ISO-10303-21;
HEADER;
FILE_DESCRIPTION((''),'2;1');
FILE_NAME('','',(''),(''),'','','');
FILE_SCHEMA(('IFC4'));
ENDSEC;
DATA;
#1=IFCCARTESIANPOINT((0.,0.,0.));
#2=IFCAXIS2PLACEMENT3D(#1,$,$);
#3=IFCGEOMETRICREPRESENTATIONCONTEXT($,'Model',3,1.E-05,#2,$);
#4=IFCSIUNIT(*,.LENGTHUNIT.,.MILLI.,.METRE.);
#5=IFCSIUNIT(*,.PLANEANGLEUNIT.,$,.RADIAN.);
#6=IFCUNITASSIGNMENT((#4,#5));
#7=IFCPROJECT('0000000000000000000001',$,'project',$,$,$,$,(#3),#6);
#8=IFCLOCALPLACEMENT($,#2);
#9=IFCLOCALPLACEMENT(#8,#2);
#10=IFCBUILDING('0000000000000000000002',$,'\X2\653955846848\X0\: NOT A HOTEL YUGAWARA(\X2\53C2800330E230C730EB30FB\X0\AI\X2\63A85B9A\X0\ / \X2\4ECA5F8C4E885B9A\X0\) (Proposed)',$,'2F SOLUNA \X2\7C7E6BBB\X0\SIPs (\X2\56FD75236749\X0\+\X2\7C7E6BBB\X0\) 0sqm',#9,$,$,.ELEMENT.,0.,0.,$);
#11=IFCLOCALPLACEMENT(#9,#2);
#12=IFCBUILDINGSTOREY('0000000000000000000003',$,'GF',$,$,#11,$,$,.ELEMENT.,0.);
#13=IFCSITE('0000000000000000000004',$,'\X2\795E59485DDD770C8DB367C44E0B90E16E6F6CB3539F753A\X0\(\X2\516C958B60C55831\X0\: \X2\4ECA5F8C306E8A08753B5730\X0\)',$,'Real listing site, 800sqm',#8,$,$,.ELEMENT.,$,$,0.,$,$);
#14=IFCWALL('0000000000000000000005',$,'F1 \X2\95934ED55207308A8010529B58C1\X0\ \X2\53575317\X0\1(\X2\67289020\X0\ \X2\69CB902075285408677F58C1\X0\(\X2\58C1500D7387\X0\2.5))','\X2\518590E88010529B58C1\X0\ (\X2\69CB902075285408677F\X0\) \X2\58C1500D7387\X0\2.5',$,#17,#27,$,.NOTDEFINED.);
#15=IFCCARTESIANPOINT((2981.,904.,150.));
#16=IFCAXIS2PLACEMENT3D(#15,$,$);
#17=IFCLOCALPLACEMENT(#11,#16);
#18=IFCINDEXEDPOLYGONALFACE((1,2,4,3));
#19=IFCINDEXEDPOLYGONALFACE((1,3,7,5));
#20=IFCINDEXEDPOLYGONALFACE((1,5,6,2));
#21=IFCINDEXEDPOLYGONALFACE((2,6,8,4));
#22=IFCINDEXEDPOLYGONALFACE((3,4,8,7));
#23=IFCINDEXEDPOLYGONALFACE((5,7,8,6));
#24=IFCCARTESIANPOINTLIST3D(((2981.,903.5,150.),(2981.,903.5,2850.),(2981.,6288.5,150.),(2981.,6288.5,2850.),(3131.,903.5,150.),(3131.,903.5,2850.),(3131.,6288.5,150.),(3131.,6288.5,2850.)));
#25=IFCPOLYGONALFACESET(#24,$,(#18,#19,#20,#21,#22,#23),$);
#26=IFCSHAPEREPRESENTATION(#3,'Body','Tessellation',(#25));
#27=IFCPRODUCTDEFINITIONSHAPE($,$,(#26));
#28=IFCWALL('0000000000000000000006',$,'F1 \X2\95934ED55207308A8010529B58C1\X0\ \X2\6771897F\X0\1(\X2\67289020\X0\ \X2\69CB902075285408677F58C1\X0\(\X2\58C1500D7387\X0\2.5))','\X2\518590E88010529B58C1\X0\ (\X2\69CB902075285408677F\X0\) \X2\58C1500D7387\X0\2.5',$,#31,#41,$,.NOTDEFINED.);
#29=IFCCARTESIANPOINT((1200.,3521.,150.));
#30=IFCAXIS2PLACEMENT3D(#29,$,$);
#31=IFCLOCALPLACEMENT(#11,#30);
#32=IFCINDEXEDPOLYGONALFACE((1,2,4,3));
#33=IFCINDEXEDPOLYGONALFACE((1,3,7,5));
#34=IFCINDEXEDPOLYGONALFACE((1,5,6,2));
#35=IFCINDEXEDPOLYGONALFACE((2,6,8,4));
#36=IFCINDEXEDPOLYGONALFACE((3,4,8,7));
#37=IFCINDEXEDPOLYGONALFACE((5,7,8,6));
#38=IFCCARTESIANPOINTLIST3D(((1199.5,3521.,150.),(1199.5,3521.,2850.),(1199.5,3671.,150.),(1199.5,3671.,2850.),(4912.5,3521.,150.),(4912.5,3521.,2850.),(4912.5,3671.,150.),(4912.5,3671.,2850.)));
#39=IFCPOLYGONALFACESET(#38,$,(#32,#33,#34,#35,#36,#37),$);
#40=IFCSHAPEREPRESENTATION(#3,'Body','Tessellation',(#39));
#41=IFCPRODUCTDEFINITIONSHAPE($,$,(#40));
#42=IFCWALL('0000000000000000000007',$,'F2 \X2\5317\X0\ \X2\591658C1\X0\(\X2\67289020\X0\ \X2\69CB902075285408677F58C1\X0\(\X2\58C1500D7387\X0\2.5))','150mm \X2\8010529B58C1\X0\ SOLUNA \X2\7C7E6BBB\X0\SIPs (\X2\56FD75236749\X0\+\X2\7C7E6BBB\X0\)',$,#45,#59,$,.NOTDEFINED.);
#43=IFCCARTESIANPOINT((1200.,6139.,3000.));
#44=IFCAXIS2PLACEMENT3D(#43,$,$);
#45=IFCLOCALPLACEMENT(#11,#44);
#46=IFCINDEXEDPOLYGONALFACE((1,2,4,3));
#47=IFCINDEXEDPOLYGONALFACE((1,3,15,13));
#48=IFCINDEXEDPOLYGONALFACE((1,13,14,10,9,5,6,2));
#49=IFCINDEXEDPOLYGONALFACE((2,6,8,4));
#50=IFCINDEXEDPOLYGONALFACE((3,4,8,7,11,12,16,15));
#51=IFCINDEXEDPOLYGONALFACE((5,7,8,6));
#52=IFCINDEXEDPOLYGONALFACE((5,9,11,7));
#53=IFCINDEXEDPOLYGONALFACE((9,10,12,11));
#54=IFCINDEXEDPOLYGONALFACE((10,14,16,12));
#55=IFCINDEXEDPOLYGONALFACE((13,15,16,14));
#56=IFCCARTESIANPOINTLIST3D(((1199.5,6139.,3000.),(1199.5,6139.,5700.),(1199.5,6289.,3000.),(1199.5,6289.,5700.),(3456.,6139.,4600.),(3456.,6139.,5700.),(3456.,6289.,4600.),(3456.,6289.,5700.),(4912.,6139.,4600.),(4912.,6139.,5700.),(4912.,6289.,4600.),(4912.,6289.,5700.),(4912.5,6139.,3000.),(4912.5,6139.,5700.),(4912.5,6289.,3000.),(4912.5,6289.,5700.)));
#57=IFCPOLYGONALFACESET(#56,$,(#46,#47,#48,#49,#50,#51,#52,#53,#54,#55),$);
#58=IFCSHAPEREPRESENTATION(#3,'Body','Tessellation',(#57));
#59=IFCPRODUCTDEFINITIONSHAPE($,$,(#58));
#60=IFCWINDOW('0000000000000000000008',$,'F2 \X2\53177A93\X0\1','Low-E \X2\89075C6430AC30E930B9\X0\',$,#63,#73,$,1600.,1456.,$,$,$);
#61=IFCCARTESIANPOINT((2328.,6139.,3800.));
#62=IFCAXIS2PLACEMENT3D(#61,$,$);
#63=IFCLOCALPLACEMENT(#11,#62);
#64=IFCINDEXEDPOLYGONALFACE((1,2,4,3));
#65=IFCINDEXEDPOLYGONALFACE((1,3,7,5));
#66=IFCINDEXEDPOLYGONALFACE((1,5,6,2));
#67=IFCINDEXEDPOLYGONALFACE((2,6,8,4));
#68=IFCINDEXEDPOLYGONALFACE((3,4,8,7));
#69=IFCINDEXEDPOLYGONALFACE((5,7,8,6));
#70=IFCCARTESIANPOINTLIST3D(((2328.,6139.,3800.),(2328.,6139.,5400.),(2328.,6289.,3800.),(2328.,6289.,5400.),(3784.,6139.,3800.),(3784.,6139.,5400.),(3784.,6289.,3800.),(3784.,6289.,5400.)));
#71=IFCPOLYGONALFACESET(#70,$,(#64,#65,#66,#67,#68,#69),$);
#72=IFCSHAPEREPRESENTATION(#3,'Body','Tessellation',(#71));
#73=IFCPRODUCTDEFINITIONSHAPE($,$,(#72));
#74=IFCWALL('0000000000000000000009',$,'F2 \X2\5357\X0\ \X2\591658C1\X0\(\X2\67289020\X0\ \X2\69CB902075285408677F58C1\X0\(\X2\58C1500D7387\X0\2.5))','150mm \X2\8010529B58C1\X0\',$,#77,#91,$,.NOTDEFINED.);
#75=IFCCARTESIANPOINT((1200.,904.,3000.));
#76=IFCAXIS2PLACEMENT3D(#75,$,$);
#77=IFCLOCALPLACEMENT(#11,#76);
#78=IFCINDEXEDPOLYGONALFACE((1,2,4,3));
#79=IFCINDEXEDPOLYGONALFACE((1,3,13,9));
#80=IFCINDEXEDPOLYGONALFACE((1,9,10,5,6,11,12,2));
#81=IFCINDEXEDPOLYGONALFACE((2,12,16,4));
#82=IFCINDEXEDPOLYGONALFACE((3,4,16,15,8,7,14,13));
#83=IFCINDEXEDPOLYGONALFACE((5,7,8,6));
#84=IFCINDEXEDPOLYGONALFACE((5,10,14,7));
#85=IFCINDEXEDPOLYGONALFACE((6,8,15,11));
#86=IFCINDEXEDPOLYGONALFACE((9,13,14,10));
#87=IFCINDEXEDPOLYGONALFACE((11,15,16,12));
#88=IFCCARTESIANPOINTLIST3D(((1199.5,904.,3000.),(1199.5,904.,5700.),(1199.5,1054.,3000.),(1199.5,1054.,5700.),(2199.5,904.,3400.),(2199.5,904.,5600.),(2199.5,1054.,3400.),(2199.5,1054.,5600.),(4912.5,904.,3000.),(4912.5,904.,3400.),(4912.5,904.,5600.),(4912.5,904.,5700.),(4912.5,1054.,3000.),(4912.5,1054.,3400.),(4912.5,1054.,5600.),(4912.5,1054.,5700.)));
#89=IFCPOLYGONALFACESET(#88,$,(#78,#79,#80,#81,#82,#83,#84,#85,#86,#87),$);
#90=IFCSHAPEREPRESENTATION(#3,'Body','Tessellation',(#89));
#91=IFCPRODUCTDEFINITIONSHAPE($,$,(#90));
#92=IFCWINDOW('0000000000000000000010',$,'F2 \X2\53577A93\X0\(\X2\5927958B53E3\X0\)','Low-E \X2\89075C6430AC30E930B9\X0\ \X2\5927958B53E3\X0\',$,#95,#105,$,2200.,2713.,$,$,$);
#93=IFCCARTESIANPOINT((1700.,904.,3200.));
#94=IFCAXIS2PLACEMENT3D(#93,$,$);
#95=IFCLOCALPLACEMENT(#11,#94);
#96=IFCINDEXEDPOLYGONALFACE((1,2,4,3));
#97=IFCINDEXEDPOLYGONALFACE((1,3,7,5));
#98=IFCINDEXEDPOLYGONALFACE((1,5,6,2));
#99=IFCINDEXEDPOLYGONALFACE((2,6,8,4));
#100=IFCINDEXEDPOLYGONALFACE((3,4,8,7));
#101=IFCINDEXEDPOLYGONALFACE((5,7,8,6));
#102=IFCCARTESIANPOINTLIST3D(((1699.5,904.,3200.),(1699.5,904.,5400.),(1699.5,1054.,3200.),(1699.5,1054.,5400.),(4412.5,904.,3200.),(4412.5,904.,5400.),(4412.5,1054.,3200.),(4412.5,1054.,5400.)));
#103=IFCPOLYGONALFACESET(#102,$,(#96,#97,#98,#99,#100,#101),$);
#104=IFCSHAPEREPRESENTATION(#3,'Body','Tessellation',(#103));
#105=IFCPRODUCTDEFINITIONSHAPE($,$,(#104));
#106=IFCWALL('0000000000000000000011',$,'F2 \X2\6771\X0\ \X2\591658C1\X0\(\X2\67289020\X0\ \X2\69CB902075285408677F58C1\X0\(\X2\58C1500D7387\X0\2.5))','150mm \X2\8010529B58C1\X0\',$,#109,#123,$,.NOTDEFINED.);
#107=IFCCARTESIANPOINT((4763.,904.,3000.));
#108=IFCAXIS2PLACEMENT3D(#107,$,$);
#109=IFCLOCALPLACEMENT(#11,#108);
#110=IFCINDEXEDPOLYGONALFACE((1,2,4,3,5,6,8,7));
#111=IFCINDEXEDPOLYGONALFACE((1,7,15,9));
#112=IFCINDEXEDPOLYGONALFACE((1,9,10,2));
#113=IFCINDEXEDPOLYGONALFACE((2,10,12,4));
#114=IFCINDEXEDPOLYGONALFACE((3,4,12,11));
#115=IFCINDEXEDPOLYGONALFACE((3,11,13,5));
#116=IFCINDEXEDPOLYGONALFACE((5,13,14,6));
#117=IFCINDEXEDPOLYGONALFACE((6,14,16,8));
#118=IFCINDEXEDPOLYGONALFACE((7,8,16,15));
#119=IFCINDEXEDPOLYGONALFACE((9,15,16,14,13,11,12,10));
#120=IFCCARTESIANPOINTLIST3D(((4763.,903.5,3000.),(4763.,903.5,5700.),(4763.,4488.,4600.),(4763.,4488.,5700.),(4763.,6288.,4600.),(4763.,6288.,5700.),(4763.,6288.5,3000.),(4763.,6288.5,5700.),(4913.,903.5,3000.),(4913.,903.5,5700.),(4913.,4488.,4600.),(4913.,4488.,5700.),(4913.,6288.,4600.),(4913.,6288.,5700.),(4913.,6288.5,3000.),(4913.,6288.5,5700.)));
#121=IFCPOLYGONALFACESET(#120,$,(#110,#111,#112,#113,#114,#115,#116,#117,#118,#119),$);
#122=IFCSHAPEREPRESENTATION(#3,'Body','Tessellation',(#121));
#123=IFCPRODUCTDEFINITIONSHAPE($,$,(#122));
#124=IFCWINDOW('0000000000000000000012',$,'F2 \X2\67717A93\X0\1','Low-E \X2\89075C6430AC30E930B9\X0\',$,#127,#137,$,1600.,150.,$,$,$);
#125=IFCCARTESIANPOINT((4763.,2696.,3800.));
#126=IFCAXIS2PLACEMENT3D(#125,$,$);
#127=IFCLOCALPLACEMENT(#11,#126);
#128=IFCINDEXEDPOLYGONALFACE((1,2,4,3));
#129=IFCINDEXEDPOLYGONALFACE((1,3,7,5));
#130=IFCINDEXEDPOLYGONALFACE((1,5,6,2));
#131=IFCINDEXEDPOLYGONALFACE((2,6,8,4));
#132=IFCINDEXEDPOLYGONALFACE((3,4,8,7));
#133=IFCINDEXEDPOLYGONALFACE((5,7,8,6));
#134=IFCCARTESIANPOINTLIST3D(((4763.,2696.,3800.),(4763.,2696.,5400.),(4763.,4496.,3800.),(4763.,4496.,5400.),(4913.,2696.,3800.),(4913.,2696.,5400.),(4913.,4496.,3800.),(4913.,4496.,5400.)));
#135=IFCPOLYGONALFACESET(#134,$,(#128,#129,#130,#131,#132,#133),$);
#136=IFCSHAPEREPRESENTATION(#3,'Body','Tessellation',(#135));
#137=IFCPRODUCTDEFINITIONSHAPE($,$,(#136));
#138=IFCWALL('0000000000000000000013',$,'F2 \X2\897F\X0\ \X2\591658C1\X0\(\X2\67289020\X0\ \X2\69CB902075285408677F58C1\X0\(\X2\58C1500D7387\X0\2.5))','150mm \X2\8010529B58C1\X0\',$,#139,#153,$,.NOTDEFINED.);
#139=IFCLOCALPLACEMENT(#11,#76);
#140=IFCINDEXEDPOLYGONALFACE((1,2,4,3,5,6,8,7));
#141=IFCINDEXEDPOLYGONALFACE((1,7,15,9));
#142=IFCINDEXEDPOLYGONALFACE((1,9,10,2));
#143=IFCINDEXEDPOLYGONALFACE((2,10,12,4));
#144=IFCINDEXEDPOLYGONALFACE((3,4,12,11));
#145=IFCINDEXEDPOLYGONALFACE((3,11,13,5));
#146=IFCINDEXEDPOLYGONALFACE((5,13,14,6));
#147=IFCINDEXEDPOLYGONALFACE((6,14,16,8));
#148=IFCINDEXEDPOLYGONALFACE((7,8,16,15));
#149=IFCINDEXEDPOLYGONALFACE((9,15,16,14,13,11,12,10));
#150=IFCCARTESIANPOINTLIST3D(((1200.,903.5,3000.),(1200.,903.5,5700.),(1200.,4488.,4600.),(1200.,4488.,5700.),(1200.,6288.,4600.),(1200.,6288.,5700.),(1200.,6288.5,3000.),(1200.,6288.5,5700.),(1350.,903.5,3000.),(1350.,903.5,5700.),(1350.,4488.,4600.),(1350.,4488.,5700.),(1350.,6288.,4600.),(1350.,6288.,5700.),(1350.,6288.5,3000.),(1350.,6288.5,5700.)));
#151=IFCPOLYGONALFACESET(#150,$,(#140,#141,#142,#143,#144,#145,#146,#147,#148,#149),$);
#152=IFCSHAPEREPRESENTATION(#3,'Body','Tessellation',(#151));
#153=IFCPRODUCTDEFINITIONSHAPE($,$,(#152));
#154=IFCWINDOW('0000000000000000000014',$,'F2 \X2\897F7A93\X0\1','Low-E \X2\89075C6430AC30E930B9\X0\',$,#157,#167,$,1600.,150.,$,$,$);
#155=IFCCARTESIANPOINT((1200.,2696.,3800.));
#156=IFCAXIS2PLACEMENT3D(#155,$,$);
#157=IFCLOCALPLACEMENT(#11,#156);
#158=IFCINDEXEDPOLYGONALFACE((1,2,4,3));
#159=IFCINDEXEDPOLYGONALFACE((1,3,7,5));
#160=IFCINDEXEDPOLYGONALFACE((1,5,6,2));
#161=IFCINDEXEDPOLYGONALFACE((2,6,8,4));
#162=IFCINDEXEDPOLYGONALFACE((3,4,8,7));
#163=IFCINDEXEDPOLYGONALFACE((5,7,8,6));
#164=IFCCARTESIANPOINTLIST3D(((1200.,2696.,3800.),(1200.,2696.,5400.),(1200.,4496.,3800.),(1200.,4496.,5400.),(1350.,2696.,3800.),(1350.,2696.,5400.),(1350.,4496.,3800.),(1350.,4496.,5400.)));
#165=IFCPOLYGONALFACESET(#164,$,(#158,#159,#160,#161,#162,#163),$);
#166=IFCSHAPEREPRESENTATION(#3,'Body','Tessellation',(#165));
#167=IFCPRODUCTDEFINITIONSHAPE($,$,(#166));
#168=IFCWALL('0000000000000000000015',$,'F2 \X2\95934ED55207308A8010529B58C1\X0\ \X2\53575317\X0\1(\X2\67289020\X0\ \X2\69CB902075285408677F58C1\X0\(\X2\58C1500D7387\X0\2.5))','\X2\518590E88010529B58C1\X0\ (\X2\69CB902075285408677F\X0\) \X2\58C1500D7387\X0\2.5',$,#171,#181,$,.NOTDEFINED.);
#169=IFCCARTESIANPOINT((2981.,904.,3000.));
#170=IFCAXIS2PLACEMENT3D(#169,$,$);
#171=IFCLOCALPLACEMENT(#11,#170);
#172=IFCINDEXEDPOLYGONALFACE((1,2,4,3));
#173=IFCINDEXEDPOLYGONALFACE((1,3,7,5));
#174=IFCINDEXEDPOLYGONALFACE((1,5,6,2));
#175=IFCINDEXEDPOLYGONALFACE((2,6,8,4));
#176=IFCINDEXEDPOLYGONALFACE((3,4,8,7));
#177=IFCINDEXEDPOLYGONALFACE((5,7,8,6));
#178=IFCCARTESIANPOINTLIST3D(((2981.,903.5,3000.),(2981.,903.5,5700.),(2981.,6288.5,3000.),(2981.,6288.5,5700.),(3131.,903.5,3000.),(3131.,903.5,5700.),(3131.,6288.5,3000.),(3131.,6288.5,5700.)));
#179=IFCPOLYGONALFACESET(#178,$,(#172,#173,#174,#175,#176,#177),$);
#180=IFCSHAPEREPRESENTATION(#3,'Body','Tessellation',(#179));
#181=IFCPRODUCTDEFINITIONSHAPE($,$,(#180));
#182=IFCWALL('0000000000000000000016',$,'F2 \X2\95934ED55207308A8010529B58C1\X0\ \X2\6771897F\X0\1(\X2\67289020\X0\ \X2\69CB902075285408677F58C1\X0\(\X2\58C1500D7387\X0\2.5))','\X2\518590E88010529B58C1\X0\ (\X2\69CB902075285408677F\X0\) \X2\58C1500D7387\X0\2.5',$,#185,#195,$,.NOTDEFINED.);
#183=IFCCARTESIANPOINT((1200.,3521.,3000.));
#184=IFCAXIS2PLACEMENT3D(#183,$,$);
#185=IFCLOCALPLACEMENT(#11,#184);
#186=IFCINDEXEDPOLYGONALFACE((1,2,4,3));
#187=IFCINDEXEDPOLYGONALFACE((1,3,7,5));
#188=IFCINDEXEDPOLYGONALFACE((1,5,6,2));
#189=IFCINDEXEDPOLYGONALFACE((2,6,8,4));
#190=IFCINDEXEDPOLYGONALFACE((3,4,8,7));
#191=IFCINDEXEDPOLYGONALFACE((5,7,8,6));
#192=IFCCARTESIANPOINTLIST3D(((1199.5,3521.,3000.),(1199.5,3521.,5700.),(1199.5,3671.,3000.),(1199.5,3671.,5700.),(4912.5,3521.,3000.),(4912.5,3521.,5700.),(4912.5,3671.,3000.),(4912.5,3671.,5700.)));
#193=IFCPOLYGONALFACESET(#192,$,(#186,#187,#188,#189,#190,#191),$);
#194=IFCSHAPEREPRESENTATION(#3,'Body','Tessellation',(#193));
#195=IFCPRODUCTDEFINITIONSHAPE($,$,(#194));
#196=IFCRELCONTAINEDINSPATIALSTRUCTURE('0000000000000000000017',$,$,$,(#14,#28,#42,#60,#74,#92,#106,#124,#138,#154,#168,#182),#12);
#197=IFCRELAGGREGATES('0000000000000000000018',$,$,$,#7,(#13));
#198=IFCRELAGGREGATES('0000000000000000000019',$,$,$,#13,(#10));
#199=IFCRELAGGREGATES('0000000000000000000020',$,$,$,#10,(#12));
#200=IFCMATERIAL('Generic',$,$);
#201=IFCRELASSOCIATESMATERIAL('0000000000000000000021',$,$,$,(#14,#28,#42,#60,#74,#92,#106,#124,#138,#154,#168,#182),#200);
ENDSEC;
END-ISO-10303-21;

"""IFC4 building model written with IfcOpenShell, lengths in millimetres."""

from ifc_helpers import new_model, si_unit, frame, frame_2d, origin, place, context, project, spatial, rectangle, extrude, material, element, fill, save


model = new_model("IFC4")

# Units and contexts
model_context = context("Model", 3, precision=1e-05, world=origin())
ifc_project = project(units=[si_unit("LENGTHUNIT", "METRE", prefix="MILLI"), si_unit("PLANEANGLEUNIT", "RADIAN")], contexts=[model_context])

# Site, building, storey
site_placement = place(None, origin())
site = spatial("IfcSite", under=ifc_project, at=site_placement, Name="神奈川県足柄下郡湯河原町(公開情報: 今後の計画地)", ObjectType="Real listing site, 800sqm", CompositionType="ELEMENT", RefElevation=0.0)
building_placement = place(site_placement, origin())
building = spatial("IfcBuilding", under=site, at=building_placement, Name="改善案: NOT A HOTEL YUGAWARA(参考モデル・AI推定 / 今後予定) (Proposed)", ObjectType="2F SOLUNA 籾殻SIPs (国産杉+籾殻) 0sqm", CompositionType="ELEMENT", ElevationOfRefHeight=0.0, ElevationOfTerrain=0.0)
storey_placement = place(building_placement, origin())
storey = spatial("IfcBuildingStorey", under=building, at=storey_placement, Name="GF", CompositionType="ELEMENT", Elevation=0.0)

# Shared definitions
ifc_material_1 = material(Name="Generic")

# Walls
wall_1_placement = place(storey_placement, frame((2981.0, 904.0, 150.0)))
element("IfcWall", 1, at=wall_1_placement, inside=storey, material=ifc_material_1, Name="F1 間仕切り耐力壁 南北1(木造 構造用合板壁(壁倍率2.5))", Description="内部耐力壁 (構造用合板) 壁倍率2.5", PredefinedType="NOTDEFINED", context=model_context, shape_type="SweptSolid", body=[
    extrude(rectangle(XDim=150.0, YDim=5385.0, at=frame_2d((75.0, 2692.0))), frame((2981.0, 904.0, 150.0)), (0.0, 0.0, 1.0), 2700.0),
])
wall_2_placement = place(storey_placement, frame((1200.0, 3521.0, 150.0)))
element("IfcWall", 2, at=wall_2_placement, inside=storey, material=ifc_material_1, Name="F1 間仕切り耐力壁 東西1(木造 構造用合板壁(壁倍率2.5))", Description="内部耐力壁 (構造用合板) 壁倍率2.5", PredefinedType="NOTDEFINED", context=model_context, shape_type="SweptSolid", body=[
    extrude(rectangle(XDim=3713.0, YDim=150.0, at=frame_2d((1856.0, 75.0))), frame((1200.0, 3521.0, 150.0)), (0.0, 0.0, 1.0), 2700.0),
])

# Walls, openings, windows
wall_3_placement = place(storey_placement, frame((1200.0, 6139.0, 3000.0)))
wall_3 = element("IfcWall", 3, at=wall_3_placement, inside=storey, material=ifc_material_1, Name="F2 北 外壁(木造 構造用合板壁(壁倍率2.5))", Description="150mm 耐力壁 SOLUNA 籾殻SIPs (国産杉+籾殻)", PredefinedType="NOTDEFINED", context=model_context, shape_type="SweptSolid", body=[
    extrude(rectangle(XDim=3713.0, YDim=150.0, at=frame_2d((1856.0, 75.0))), frame((1200.0, 6139.0, 3000.0)), (0.0, 0.0, 1.0), 2700.0),
])
opening_1_placement = place(storey_placement, frame((2328.0, 6139.0, 3800.0)))
opening_1 = element("IfcOpeningElement", 4, at=opening_1_placement, cuts=wall_3, PredefinedType="NOTDEFINED", context=model_context, shape_type="SweptSolid", body=[
    extrude(rectangle(XDim=1456.0, YDim=150.0, at=frame_2d((728.0, 75.0))), frame((2328.0, 6139.0, 3800.0)), (0.0, 0.0, 1.0), 1600.0),
])
window_1_placement = place(storey_placement, frame((2328.0, 6139.0, 3800.0)))
window_1 = element("IfcWindow", 5, at=window_1_placement, inside=storey, material=ifc_material_1, Name="F2 北窓1", Description="Low-E 複層ガラス", OverallHeight=1600.0, OverallWidth=1456.0, context=model_context, shape_type="SweptSolid", body=[
    extrude(rectangle(XDim=1456.0, YDim=150.0, at=frame_2d((728.0, 75.0))), frame((2328.0, 6139.0, 3800.0)), (0.0, 0.0, 1.0), 1600.0),
])
fill(opening_1, window_1)
wall_4_placement = place(storey_placement, frame((1200.0, 904.0, 3000.0)))
wall_4 = element("IfcWall", 6, at=wall_4_placement, inside=storey, material=ifc_material_1, Name="F2 南 外壁(木造 構造用合板壁(壁倍率2.5))", Description="150mm 耐力壁", PredefinedType="NOTDEFINED", context=model_context, shape_type="SweptSolid", body=[
    extrude(rectangle(XDim=3713.0, YDim=150.0, at=frame_2d((1856.0, 75.0))), frame((1200.0, 904.0, 3000.0)), (0.0, 0.0, 1.0), 2700.0),
])
opening_2_placement = place(storey_placement, frame((1700.0, 904.0, 3200.0)))
opening_2 = element("IfcOpeningElement", 7, at=opening_2_placement, cuts=wall_4, PredefinedType="NOTDEFINED", context=model_context, shape_type="SweptSolid", body=[
    extrude(rectangle(XDim=2713.0, YDim=150.0, at=frame_2d((1356.0, 75.0))), frame((1700.0, 904.0, 3200.0)), (0.0, 0.0, 1.0), 2200.0),
])
window_2_placement = place(storey_placement, frame((1700.0, 904.0, 3200.0)))
window_2 = element("IfcWindow", 8, at=window_2_placement, inside=storey, material=ifc_material_1, Name="F2 南窓(大開口)", Description="Low-E 複層ガラス 大開口", OverallHeight=2200.0, OverallWidth=2713.0, context=model_context, shape_type="SweptSolid", body=[
    extrude(rectangle(XDim=2713.0, YDim=150.0, at=frame_2d((1356.0, 75.0))), frame((1700.0, 904.0, 3200.0)), (0.0, 0.0, 1.0), 2200.0),
])
fill(opening_2, window_2)
wall_5_placement = place(storey_placement, frame((4763.0, 904.0, 3000.0)))
wall_5 = element("IfcWall", 9, at=wall_5_placement, inside=storey, material=ifc_material_1, Name="F2 東 外壁(木造 構造用合板壁(壁倍率2.5))", Description="150mm 耐力壁", PredefinedType="NOTDEFINED", context=model_context, shape_type="SweptSolid", body=[
    extrude(rectangle(XDim=150.0, YDim=5385.0, at=frame_2d((75.0, 2692.0))), frame((4763.0, 904.0, 3000.0)), (0.0, 0.0, 1.0), 2700.0),
])
opening_3_placement = place(storey_placement, frame((4763.0, 2696.0, 3800.0)))
opening_3 = element("IfcOpeningElement", 10, at=opening_3_placement, cuts=wall_5, PredefinedType="NOTDEFINED", context=model_context, shape_type="SweptSolid", body=[
    extrude(rectangle(XDim=150.0, YDim=1800.0, at=frame_2d((75.0, 900.0))), frame((4763.0, 2696.0, 3800.0)), (0.0, 0.0, 1.0), 1600.0),
])
window_3_placement = place(storey_placement, frame((4763.0, 2696.0, 3800.0)))
window_3 = element("IfcWindow", 11, at=window_3_placement, inside=storey, material=ifc_material_1, Name="F2 東窓1", Description="Low-E 複層ガラス", OverallHeight=1600.0, OverallWidth=150.0, context=model_context, shape_type="SweptSolid", body=[
    extrude(rectangle(XDim=150.0, YDim=1800.0, at=frame_2d((75.0, 900.0))), frame((4763.0, 2696.0, 3800.0)), (0.0, 0.0, 1.0), 1600.0),
])
fill(opening_3, window_3)
wall_6_placement = place(storey_placement, frame((1200.0, 904.0, 3000.0)))
wall_6 = element("IfcWall", 12, at=wall_6_placement, inside=storey, material=ifc_material_1, Name="F2 西 外壁(木造 構造用合板壁(壁倍率2.5))", Description="150mm 耐力壁", PredefinedType="NOTDEFINED", context=model_context, shape_type="SweptSolid", body=[
    extrude(rectangle(XDim=150.0, YDim=5385.0, at=frame_2d((75.0, 2692.0))), frame((1200.0, 904.0, 3000.0)), (0.0, 0.0, 1.0), 2700.0),
])
opening_4_placement = place(storey_placement, frame((1200.0, 2696.0, 3800.0)))
opening_4 = element("IfcOpeningElement", 13, at=opening_4_placement, cuts=wall_6, PredefinedType="NOTDEFINED", context=model_context, shape_type="SweptSolid", body=[
    extrude(rectangle(XDim=150.0, YDim=1800.0, at=frame_2d((75.0, 900.0))), frame((1200.0, 2696.0, 3800.0)), (0.0, 0.0, 1.0), 1600.0),
])
window_4_placement = place(storey_placement, frame((1200.0, 2696.0, 3800.0)))
window_4 = element("IfcWindow", 14, at=window_4_placement, inside=storey, material=ifc_material_1, Name="F2 西窓1", Description="Low-E 複層ガラス", OverallHeight=1600.0, OverallWidth=150.0, context=model_context, shape_type="SweptSolid", body=[
    extrude(rectangle(XDim=150.0, YDim=1800.0, at=frame_2d((75.0, 900.0))), frame((1200.0, 2696.0, 3800.0)), (0.0, 0.0, 1.0), 1600.0),
])
fill(opening_4, window_4)

# Walls
wall_7_placement = place(storey_placement, frame((2981.0, 904.0, 3000.0)))
element("IfcWall", 15, at=wall_7_placement, inside=storey, material=ifc_material_1, Name="F2 間仕切り耐力壁 南北1(木造 構造用合板壁(壁倍率2.5))", Description="内部耐力壁 (構造用合板) 壁倍率2.5", PredefinedType="NOTDEFINED", context=model_context, shape_type="SweptSolid", body=[
    extrude(rectangle(XDim=150.0, YDim=5385.0, at=frame_2d((75.0, 2692.0))), frame((2981.0, 904.0, 3000.0)), (0.0, 0.0, 1.0), 2700.0),
])
wall_8_placement = place(storey_placement, frame((1200.0, 3521.0, 3000.0)))
element("IfcWall", 16, at=wall_8_placement, inside=storey, material=ifc_material_1, Name="F2 間仕切り耐力壁 東西1(木造 構造用合板壁(壁倍率2.5))", Description="内部耐力壁 (構造用合板) 壁倍率2.5", PredefinedType="NOTDEFINED", context=model_context, shape_type="SweptSolid", body=[
    extrude(rectangle(XDim=3713.0, YDim=150.0, at=frame_2d((1856.0, 75.0))), frame((1200.0, 3521.0, 3000.0)), (0.0, 0.0, 1.0), 2700.0),
])

save(model, "model.ifc")
